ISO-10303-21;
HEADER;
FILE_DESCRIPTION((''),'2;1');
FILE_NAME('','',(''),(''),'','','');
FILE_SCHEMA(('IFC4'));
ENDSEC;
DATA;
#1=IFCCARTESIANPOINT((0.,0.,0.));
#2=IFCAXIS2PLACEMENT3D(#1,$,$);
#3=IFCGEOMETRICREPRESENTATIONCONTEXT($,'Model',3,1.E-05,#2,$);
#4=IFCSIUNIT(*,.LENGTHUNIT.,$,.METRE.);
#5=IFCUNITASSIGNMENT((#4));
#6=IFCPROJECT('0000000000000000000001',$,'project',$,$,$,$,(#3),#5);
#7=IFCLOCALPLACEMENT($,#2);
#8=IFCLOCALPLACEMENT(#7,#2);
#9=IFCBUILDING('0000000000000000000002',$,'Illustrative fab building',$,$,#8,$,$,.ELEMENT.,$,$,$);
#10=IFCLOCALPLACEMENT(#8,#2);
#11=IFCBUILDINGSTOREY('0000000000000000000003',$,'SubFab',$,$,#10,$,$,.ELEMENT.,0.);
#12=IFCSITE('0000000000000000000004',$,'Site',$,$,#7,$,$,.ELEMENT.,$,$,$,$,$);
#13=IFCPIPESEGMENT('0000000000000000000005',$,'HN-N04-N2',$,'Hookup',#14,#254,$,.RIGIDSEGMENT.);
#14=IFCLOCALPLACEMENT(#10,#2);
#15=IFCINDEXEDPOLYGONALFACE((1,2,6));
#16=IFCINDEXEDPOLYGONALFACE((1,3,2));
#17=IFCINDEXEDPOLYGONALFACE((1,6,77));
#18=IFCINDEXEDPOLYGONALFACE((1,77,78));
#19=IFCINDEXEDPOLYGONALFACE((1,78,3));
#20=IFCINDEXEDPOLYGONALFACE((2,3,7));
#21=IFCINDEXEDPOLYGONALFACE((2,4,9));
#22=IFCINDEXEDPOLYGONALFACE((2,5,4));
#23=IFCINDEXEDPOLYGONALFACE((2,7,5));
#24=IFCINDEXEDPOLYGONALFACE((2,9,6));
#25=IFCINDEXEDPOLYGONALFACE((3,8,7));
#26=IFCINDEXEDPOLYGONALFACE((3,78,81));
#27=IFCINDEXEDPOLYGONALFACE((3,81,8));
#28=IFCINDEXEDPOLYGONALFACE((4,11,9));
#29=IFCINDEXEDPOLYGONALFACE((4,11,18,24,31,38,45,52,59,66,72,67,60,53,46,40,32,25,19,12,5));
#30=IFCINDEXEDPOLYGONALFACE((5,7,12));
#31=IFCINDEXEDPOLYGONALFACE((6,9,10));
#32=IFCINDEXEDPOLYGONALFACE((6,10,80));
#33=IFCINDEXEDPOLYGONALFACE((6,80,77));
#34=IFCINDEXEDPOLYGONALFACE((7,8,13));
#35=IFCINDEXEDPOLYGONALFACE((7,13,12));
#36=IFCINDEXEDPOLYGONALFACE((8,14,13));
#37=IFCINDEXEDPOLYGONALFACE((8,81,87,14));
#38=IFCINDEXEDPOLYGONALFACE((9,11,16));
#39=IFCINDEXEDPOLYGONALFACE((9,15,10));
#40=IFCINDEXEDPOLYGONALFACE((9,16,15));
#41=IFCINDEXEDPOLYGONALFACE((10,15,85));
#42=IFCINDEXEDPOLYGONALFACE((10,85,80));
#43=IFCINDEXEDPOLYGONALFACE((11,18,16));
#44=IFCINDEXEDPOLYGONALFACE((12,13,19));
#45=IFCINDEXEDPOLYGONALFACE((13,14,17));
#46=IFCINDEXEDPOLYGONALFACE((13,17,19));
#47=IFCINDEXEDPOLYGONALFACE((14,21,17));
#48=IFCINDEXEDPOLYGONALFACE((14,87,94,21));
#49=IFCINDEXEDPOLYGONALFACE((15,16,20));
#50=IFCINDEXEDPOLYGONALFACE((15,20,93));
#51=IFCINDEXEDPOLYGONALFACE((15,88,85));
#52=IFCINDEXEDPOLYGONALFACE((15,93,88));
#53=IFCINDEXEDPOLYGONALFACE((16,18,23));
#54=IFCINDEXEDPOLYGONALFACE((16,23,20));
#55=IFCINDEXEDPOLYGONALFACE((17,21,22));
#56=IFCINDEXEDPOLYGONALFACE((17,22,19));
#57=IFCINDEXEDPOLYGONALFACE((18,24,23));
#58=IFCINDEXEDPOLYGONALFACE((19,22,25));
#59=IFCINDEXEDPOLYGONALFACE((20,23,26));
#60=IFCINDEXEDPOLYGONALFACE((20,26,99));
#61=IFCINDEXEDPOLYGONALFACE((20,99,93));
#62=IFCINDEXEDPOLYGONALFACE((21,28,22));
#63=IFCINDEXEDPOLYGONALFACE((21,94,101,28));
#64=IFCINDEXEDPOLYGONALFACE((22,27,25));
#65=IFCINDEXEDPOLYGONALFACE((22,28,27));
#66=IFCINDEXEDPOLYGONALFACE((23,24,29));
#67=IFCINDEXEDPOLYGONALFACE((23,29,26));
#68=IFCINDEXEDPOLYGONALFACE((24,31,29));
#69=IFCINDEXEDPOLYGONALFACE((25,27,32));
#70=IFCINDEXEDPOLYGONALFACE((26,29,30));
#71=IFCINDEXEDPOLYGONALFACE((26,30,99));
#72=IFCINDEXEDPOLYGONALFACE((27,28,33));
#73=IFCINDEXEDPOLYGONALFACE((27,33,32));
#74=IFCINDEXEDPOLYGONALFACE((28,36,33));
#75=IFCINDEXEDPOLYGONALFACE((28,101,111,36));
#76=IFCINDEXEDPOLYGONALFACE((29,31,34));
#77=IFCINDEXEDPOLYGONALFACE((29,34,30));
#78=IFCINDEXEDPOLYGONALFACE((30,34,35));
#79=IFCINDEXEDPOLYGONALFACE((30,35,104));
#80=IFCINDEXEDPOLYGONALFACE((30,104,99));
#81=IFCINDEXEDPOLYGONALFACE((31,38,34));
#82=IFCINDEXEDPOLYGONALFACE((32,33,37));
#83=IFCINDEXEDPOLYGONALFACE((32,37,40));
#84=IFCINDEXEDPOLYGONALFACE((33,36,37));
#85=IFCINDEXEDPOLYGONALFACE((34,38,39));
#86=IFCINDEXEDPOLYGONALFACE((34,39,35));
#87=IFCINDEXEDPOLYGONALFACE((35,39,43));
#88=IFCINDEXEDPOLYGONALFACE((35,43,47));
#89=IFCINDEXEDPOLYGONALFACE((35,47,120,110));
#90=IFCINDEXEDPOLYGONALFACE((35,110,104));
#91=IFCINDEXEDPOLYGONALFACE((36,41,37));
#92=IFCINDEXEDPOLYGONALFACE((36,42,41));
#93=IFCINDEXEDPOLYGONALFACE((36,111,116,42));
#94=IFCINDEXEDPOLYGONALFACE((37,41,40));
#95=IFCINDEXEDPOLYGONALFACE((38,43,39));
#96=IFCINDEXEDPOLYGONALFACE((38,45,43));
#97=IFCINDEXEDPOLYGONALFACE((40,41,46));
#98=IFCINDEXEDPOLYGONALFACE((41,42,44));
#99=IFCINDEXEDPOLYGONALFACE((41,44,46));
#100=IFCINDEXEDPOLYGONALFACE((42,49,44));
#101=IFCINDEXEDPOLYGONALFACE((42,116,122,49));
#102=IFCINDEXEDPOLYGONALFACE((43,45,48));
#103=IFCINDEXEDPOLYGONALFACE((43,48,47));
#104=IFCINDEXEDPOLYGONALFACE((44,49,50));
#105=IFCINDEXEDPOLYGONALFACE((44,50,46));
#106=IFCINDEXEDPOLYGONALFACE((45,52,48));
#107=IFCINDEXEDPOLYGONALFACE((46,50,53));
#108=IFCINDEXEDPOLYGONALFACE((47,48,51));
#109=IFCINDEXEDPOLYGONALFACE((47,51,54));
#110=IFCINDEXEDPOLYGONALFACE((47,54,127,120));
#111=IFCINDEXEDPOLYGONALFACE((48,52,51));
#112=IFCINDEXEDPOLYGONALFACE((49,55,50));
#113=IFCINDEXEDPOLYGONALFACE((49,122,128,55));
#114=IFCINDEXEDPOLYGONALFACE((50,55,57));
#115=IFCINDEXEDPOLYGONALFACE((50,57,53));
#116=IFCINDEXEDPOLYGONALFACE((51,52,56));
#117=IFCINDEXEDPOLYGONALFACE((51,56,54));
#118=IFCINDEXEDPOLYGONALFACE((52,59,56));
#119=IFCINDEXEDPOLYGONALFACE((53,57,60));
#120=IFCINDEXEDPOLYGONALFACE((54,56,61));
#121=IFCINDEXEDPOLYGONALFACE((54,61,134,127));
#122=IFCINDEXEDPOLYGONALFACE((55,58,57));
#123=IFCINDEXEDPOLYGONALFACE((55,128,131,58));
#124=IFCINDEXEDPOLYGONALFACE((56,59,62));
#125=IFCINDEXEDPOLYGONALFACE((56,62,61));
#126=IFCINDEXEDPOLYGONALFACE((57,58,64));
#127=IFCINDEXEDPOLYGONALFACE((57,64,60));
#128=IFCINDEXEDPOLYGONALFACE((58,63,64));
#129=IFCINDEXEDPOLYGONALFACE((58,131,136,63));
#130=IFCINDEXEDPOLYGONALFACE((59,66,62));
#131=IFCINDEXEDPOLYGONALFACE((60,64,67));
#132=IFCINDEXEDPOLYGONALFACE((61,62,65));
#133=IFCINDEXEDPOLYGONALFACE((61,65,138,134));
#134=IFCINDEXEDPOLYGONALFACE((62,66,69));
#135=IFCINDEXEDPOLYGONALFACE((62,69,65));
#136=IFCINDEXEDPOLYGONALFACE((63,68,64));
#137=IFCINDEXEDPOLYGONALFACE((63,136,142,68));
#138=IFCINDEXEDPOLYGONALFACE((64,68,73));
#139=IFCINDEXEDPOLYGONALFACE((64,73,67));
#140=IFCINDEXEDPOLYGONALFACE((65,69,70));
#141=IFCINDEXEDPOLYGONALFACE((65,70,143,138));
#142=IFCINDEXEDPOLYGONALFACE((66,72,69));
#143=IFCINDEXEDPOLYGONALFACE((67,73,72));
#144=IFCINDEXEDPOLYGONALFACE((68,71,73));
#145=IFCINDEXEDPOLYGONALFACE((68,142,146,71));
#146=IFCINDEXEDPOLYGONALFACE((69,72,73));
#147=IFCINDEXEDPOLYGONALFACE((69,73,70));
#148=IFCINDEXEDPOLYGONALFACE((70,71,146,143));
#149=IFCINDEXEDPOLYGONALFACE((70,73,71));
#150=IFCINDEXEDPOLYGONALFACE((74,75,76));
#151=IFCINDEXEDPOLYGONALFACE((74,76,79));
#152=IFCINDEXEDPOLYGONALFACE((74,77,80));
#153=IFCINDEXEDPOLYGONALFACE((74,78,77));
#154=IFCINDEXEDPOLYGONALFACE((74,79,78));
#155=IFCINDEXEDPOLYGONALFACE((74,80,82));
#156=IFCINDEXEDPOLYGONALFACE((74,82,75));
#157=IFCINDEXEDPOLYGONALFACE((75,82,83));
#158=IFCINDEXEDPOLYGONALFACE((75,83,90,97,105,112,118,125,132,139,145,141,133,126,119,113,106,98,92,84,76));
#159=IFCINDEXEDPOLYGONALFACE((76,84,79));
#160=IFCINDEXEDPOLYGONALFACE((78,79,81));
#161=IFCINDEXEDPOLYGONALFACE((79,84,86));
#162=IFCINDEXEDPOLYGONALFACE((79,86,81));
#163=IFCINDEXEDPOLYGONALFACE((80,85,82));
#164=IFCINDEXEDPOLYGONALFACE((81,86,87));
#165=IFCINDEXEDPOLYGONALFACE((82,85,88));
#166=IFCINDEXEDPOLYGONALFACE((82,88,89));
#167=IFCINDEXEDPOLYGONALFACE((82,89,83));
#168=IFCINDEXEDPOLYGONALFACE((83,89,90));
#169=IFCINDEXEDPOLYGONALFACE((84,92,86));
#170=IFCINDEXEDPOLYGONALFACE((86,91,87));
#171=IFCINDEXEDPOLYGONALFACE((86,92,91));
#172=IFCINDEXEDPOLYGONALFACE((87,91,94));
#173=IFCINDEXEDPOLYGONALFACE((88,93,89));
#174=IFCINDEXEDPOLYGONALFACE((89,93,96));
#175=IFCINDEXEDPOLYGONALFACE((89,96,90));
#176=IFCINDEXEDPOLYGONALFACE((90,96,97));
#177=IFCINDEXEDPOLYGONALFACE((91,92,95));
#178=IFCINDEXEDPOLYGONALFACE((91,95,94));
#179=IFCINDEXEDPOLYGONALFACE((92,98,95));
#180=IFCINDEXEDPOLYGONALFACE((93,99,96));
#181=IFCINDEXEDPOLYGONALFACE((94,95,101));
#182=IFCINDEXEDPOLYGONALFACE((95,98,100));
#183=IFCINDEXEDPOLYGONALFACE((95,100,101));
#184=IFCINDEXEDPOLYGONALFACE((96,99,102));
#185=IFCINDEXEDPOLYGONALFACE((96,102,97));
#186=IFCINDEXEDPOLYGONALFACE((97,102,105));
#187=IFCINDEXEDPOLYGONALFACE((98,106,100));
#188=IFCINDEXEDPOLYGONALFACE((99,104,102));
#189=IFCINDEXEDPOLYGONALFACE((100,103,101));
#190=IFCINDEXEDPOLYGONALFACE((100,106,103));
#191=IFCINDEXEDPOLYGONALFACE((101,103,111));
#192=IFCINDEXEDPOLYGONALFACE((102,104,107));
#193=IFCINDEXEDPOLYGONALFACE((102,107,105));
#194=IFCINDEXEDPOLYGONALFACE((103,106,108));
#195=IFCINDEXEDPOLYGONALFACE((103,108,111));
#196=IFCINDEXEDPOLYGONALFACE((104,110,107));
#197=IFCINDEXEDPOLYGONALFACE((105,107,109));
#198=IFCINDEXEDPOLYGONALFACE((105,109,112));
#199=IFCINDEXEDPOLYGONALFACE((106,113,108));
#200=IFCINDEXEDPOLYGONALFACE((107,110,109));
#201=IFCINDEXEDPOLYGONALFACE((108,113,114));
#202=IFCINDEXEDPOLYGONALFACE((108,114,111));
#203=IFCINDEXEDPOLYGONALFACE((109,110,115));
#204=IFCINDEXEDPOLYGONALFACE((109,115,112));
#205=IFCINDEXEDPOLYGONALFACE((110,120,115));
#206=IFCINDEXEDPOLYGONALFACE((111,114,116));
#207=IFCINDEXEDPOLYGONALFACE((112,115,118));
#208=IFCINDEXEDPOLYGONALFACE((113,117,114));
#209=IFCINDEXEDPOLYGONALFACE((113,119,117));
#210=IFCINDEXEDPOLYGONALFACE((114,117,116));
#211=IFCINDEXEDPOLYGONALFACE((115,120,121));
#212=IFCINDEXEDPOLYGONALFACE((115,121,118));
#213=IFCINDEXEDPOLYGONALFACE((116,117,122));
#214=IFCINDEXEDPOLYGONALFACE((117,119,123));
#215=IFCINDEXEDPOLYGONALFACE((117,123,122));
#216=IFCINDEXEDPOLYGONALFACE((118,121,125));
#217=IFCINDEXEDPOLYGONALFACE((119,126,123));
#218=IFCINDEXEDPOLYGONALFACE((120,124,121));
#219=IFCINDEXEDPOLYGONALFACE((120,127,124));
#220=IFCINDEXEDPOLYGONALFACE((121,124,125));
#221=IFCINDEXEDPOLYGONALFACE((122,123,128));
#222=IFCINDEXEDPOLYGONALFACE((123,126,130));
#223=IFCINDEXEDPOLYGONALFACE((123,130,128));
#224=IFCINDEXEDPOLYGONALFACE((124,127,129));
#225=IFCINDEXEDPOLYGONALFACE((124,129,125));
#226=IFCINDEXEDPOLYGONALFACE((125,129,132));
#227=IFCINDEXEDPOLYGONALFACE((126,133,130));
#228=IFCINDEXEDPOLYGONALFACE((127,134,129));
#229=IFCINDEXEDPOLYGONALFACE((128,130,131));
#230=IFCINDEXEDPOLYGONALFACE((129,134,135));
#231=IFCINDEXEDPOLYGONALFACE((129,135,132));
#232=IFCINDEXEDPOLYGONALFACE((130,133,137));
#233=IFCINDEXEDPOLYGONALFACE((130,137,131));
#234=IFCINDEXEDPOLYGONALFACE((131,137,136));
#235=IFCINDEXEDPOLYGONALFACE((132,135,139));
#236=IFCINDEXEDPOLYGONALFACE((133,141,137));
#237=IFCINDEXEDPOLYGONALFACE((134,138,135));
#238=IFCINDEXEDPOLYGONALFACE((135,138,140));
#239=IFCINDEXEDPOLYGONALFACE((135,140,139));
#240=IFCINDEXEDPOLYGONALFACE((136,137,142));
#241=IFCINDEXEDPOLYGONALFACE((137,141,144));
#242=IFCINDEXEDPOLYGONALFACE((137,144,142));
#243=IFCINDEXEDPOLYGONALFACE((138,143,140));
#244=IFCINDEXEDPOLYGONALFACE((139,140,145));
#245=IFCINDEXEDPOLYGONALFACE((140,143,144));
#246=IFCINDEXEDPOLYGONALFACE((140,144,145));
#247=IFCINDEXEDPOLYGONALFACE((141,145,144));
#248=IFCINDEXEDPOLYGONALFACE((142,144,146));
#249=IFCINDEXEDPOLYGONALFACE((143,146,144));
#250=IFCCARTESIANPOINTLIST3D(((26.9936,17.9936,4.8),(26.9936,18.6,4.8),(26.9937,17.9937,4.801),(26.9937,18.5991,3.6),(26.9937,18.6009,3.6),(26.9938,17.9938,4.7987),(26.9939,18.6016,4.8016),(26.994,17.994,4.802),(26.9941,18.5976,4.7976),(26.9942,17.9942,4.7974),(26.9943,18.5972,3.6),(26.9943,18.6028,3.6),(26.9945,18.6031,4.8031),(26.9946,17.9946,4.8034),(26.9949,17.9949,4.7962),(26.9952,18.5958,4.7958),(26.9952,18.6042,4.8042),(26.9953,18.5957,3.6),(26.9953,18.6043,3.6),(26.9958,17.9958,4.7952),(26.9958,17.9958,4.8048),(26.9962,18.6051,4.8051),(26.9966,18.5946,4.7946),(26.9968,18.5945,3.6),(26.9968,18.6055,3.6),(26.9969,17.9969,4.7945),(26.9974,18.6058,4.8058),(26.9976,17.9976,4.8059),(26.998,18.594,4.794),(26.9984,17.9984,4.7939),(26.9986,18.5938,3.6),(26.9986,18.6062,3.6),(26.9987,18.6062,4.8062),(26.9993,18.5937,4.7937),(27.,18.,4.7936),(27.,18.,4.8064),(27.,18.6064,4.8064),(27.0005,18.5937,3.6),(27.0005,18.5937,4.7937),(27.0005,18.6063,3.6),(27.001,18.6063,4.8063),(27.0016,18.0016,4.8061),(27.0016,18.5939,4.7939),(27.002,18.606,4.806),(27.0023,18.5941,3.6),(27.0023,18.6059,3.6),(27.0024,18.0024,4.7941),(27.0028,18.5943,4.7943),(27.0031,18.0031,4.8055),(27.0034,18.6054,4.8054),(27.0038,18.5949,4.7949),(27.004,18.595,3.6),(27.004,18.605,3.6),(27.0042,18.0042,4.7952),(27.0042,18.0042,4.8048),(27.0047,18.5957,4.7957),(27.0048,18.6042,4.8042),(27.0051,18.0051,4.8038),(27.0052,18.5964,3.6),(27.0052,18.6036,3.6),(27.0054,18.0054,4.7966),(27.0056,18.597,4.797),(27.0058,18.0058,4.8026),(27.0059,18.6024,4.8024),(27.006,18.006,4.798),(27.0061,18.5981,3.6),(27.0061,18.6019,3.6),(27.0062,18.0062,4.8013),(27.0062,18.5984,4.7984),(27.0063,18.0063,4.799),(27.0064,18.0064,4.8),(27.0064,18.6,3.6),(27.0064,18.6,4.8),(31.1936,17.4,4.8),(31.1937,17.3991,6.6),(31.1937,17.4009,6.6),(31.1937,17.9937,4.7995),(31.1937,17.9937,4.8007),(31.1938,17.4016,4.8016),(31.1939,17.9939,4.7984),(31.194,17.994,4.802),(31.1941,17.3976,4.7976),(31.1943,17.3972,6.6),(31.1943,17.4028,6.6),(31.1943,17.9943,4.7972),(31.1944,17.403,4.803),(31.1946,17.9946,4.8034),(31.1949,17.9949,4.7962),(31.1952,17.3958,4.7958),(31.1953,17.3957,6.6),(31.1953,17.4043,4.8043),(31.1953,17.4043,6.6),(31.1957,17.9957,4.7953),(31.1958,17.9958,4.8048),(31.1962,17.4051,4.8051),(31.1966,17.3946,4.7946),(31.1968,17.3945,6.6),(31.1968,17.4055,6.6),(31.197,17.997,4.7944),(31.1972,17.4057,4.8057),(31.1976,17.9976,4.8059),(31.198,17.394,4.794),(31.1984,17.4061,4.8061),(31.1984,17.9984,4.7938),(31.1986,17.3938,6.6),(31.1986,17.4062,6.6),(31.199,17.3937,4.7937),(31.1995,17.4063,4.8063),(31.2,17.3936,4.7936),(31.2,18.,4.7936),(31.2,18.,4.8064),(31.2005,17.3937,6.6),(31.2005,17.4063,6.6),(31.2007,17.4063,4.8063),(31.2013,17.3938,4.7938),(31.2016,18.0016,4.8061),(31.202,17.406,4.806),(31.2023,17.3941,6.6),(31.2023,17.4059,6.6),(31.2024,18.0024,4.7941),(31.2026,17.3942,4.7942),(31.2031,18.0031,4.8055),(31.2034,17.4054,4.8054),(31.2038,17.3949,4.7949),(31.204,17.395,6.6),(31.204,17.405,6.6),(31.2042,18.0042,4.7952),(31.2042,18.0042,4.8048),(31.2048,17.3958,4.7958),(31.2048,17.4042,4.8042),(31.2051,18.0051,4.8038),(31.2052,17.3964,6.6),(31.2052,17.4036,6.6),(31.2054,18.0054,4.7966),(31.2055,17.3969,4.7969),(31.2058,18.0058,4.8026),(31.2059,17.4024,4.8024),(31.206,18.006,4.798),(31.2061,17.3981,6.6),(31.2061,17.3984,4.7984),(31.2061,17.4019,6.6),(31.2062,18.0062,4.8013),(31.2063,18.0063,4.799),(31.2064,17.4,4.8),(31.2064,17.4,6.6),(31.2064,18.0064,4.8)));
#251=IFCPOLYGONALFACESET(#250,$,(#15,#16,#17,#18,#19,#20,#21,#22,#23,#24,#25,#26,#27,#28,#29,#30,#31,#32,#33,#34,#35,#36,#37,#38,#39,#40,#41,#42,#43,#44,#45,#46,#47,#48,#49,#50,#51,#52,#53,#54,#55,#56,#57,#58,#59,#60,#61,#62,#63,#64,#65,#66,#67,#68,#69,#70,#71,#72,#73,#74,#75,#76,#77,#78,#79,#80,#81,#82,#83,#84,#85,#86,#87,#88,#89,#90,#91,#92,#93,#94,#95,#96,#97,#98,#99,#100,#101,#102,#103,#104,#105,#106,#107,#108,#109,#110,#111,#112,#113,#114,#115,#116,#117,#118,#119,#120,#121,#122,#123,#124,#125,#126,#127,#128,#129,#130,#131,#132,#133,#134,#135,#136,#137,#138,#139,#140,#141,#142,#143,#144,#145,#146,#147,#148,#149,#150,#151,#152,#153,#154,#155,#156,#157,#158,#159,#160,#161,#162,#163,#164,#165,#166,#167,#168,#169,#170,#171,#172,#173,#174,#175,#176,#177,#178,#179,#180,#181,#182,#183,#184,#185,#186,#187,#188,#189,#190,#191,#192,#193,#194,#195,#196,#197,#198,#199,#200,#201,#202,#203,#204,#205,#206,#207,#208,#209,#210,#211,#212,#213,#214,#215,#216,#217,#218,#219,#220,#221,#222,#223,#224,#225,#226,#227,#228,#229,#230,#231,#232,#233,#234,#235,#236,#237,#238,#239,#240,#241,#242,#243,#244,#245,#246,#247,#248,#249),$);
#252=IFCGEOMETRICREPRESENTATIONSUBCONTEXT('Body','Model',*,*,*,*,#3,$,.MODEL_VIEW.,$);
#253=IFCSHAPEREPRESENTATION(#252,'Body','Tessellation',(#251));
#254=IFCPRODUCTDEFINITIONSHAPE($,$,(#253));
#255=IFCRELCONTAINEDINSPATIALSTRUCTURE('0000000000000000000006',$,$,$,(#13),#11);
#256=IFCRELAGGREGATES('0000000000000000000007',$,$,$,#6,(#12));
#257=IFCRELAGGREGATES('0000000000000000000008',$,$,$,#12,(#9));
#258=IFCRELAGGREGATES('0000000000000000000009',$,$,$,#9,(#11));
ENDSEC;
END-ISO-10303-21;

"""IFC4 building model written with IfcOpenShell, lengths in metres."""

from ifc_helpers import new_model, entity, si_unit, origin, place, context, subcontext, project, spatial, element, save


model = new_model("IFC4")

# Units and contexts
model_context = context("Model", 3, precision=1e-05, world=origin())
body_context = subcontext(model_context, "Body", "Model", "MODEL_VIEW")
ifc_project = project(units=[si_unit("LENGTHUNIT", "METRE")], contexts=[model_context])

# Site, building, storey
site_placement = place(None, origin())
site = spatial("IfcSite", under=ifc_project, at=site_placement, Name="Site", CompositionType="ELEMENT")
building_placement = place(site_placement, origin())
building = spatial("IfcBuilding", under=site, at=building_placement, Name="Illustrative fab building", CompositionType="ELEMENT")
storey_placement = place(building_placement, origin())
storey = spatial("IfcBuildingStorey", under=building, at=storey_placement, Name="SubFab", CompositionType="ELEMENT", Elevation=0.0)

# Pipe segment
pipe_segment_1_placement = place(storey_placement, origin())
element("IfcPipeSegment", 1, at=pipe_segment_1_placement, inside=storey, Name="HN-N04-N2", ObjectType="Hookup", PredefinedType="RIGIDSEGMENT", context=body_context, shape_type="AdvancedSweptSolid", body=[
    entity("IfcSweptDiskSolid", entity("IfcPolyline", [entity("IfcCartesianPoint", [27.0, 18.6, 3.6]), entity("IfcCartesianPoint", [27.0, 18.6, 4.8]), entity("IfcCartesianPoint", [27.0, 18.0, 4.8]), entity("IfcCartesianPoint", [31.2, 18.0, 4.8]), entity("IfcCartesianPoint", [31.2, 17.4, 4.8]), entity("IfcCartesianPoint", [31.2, 17.4, 6.6])]), 0.0063),
])

save(model, "model.ifc")
